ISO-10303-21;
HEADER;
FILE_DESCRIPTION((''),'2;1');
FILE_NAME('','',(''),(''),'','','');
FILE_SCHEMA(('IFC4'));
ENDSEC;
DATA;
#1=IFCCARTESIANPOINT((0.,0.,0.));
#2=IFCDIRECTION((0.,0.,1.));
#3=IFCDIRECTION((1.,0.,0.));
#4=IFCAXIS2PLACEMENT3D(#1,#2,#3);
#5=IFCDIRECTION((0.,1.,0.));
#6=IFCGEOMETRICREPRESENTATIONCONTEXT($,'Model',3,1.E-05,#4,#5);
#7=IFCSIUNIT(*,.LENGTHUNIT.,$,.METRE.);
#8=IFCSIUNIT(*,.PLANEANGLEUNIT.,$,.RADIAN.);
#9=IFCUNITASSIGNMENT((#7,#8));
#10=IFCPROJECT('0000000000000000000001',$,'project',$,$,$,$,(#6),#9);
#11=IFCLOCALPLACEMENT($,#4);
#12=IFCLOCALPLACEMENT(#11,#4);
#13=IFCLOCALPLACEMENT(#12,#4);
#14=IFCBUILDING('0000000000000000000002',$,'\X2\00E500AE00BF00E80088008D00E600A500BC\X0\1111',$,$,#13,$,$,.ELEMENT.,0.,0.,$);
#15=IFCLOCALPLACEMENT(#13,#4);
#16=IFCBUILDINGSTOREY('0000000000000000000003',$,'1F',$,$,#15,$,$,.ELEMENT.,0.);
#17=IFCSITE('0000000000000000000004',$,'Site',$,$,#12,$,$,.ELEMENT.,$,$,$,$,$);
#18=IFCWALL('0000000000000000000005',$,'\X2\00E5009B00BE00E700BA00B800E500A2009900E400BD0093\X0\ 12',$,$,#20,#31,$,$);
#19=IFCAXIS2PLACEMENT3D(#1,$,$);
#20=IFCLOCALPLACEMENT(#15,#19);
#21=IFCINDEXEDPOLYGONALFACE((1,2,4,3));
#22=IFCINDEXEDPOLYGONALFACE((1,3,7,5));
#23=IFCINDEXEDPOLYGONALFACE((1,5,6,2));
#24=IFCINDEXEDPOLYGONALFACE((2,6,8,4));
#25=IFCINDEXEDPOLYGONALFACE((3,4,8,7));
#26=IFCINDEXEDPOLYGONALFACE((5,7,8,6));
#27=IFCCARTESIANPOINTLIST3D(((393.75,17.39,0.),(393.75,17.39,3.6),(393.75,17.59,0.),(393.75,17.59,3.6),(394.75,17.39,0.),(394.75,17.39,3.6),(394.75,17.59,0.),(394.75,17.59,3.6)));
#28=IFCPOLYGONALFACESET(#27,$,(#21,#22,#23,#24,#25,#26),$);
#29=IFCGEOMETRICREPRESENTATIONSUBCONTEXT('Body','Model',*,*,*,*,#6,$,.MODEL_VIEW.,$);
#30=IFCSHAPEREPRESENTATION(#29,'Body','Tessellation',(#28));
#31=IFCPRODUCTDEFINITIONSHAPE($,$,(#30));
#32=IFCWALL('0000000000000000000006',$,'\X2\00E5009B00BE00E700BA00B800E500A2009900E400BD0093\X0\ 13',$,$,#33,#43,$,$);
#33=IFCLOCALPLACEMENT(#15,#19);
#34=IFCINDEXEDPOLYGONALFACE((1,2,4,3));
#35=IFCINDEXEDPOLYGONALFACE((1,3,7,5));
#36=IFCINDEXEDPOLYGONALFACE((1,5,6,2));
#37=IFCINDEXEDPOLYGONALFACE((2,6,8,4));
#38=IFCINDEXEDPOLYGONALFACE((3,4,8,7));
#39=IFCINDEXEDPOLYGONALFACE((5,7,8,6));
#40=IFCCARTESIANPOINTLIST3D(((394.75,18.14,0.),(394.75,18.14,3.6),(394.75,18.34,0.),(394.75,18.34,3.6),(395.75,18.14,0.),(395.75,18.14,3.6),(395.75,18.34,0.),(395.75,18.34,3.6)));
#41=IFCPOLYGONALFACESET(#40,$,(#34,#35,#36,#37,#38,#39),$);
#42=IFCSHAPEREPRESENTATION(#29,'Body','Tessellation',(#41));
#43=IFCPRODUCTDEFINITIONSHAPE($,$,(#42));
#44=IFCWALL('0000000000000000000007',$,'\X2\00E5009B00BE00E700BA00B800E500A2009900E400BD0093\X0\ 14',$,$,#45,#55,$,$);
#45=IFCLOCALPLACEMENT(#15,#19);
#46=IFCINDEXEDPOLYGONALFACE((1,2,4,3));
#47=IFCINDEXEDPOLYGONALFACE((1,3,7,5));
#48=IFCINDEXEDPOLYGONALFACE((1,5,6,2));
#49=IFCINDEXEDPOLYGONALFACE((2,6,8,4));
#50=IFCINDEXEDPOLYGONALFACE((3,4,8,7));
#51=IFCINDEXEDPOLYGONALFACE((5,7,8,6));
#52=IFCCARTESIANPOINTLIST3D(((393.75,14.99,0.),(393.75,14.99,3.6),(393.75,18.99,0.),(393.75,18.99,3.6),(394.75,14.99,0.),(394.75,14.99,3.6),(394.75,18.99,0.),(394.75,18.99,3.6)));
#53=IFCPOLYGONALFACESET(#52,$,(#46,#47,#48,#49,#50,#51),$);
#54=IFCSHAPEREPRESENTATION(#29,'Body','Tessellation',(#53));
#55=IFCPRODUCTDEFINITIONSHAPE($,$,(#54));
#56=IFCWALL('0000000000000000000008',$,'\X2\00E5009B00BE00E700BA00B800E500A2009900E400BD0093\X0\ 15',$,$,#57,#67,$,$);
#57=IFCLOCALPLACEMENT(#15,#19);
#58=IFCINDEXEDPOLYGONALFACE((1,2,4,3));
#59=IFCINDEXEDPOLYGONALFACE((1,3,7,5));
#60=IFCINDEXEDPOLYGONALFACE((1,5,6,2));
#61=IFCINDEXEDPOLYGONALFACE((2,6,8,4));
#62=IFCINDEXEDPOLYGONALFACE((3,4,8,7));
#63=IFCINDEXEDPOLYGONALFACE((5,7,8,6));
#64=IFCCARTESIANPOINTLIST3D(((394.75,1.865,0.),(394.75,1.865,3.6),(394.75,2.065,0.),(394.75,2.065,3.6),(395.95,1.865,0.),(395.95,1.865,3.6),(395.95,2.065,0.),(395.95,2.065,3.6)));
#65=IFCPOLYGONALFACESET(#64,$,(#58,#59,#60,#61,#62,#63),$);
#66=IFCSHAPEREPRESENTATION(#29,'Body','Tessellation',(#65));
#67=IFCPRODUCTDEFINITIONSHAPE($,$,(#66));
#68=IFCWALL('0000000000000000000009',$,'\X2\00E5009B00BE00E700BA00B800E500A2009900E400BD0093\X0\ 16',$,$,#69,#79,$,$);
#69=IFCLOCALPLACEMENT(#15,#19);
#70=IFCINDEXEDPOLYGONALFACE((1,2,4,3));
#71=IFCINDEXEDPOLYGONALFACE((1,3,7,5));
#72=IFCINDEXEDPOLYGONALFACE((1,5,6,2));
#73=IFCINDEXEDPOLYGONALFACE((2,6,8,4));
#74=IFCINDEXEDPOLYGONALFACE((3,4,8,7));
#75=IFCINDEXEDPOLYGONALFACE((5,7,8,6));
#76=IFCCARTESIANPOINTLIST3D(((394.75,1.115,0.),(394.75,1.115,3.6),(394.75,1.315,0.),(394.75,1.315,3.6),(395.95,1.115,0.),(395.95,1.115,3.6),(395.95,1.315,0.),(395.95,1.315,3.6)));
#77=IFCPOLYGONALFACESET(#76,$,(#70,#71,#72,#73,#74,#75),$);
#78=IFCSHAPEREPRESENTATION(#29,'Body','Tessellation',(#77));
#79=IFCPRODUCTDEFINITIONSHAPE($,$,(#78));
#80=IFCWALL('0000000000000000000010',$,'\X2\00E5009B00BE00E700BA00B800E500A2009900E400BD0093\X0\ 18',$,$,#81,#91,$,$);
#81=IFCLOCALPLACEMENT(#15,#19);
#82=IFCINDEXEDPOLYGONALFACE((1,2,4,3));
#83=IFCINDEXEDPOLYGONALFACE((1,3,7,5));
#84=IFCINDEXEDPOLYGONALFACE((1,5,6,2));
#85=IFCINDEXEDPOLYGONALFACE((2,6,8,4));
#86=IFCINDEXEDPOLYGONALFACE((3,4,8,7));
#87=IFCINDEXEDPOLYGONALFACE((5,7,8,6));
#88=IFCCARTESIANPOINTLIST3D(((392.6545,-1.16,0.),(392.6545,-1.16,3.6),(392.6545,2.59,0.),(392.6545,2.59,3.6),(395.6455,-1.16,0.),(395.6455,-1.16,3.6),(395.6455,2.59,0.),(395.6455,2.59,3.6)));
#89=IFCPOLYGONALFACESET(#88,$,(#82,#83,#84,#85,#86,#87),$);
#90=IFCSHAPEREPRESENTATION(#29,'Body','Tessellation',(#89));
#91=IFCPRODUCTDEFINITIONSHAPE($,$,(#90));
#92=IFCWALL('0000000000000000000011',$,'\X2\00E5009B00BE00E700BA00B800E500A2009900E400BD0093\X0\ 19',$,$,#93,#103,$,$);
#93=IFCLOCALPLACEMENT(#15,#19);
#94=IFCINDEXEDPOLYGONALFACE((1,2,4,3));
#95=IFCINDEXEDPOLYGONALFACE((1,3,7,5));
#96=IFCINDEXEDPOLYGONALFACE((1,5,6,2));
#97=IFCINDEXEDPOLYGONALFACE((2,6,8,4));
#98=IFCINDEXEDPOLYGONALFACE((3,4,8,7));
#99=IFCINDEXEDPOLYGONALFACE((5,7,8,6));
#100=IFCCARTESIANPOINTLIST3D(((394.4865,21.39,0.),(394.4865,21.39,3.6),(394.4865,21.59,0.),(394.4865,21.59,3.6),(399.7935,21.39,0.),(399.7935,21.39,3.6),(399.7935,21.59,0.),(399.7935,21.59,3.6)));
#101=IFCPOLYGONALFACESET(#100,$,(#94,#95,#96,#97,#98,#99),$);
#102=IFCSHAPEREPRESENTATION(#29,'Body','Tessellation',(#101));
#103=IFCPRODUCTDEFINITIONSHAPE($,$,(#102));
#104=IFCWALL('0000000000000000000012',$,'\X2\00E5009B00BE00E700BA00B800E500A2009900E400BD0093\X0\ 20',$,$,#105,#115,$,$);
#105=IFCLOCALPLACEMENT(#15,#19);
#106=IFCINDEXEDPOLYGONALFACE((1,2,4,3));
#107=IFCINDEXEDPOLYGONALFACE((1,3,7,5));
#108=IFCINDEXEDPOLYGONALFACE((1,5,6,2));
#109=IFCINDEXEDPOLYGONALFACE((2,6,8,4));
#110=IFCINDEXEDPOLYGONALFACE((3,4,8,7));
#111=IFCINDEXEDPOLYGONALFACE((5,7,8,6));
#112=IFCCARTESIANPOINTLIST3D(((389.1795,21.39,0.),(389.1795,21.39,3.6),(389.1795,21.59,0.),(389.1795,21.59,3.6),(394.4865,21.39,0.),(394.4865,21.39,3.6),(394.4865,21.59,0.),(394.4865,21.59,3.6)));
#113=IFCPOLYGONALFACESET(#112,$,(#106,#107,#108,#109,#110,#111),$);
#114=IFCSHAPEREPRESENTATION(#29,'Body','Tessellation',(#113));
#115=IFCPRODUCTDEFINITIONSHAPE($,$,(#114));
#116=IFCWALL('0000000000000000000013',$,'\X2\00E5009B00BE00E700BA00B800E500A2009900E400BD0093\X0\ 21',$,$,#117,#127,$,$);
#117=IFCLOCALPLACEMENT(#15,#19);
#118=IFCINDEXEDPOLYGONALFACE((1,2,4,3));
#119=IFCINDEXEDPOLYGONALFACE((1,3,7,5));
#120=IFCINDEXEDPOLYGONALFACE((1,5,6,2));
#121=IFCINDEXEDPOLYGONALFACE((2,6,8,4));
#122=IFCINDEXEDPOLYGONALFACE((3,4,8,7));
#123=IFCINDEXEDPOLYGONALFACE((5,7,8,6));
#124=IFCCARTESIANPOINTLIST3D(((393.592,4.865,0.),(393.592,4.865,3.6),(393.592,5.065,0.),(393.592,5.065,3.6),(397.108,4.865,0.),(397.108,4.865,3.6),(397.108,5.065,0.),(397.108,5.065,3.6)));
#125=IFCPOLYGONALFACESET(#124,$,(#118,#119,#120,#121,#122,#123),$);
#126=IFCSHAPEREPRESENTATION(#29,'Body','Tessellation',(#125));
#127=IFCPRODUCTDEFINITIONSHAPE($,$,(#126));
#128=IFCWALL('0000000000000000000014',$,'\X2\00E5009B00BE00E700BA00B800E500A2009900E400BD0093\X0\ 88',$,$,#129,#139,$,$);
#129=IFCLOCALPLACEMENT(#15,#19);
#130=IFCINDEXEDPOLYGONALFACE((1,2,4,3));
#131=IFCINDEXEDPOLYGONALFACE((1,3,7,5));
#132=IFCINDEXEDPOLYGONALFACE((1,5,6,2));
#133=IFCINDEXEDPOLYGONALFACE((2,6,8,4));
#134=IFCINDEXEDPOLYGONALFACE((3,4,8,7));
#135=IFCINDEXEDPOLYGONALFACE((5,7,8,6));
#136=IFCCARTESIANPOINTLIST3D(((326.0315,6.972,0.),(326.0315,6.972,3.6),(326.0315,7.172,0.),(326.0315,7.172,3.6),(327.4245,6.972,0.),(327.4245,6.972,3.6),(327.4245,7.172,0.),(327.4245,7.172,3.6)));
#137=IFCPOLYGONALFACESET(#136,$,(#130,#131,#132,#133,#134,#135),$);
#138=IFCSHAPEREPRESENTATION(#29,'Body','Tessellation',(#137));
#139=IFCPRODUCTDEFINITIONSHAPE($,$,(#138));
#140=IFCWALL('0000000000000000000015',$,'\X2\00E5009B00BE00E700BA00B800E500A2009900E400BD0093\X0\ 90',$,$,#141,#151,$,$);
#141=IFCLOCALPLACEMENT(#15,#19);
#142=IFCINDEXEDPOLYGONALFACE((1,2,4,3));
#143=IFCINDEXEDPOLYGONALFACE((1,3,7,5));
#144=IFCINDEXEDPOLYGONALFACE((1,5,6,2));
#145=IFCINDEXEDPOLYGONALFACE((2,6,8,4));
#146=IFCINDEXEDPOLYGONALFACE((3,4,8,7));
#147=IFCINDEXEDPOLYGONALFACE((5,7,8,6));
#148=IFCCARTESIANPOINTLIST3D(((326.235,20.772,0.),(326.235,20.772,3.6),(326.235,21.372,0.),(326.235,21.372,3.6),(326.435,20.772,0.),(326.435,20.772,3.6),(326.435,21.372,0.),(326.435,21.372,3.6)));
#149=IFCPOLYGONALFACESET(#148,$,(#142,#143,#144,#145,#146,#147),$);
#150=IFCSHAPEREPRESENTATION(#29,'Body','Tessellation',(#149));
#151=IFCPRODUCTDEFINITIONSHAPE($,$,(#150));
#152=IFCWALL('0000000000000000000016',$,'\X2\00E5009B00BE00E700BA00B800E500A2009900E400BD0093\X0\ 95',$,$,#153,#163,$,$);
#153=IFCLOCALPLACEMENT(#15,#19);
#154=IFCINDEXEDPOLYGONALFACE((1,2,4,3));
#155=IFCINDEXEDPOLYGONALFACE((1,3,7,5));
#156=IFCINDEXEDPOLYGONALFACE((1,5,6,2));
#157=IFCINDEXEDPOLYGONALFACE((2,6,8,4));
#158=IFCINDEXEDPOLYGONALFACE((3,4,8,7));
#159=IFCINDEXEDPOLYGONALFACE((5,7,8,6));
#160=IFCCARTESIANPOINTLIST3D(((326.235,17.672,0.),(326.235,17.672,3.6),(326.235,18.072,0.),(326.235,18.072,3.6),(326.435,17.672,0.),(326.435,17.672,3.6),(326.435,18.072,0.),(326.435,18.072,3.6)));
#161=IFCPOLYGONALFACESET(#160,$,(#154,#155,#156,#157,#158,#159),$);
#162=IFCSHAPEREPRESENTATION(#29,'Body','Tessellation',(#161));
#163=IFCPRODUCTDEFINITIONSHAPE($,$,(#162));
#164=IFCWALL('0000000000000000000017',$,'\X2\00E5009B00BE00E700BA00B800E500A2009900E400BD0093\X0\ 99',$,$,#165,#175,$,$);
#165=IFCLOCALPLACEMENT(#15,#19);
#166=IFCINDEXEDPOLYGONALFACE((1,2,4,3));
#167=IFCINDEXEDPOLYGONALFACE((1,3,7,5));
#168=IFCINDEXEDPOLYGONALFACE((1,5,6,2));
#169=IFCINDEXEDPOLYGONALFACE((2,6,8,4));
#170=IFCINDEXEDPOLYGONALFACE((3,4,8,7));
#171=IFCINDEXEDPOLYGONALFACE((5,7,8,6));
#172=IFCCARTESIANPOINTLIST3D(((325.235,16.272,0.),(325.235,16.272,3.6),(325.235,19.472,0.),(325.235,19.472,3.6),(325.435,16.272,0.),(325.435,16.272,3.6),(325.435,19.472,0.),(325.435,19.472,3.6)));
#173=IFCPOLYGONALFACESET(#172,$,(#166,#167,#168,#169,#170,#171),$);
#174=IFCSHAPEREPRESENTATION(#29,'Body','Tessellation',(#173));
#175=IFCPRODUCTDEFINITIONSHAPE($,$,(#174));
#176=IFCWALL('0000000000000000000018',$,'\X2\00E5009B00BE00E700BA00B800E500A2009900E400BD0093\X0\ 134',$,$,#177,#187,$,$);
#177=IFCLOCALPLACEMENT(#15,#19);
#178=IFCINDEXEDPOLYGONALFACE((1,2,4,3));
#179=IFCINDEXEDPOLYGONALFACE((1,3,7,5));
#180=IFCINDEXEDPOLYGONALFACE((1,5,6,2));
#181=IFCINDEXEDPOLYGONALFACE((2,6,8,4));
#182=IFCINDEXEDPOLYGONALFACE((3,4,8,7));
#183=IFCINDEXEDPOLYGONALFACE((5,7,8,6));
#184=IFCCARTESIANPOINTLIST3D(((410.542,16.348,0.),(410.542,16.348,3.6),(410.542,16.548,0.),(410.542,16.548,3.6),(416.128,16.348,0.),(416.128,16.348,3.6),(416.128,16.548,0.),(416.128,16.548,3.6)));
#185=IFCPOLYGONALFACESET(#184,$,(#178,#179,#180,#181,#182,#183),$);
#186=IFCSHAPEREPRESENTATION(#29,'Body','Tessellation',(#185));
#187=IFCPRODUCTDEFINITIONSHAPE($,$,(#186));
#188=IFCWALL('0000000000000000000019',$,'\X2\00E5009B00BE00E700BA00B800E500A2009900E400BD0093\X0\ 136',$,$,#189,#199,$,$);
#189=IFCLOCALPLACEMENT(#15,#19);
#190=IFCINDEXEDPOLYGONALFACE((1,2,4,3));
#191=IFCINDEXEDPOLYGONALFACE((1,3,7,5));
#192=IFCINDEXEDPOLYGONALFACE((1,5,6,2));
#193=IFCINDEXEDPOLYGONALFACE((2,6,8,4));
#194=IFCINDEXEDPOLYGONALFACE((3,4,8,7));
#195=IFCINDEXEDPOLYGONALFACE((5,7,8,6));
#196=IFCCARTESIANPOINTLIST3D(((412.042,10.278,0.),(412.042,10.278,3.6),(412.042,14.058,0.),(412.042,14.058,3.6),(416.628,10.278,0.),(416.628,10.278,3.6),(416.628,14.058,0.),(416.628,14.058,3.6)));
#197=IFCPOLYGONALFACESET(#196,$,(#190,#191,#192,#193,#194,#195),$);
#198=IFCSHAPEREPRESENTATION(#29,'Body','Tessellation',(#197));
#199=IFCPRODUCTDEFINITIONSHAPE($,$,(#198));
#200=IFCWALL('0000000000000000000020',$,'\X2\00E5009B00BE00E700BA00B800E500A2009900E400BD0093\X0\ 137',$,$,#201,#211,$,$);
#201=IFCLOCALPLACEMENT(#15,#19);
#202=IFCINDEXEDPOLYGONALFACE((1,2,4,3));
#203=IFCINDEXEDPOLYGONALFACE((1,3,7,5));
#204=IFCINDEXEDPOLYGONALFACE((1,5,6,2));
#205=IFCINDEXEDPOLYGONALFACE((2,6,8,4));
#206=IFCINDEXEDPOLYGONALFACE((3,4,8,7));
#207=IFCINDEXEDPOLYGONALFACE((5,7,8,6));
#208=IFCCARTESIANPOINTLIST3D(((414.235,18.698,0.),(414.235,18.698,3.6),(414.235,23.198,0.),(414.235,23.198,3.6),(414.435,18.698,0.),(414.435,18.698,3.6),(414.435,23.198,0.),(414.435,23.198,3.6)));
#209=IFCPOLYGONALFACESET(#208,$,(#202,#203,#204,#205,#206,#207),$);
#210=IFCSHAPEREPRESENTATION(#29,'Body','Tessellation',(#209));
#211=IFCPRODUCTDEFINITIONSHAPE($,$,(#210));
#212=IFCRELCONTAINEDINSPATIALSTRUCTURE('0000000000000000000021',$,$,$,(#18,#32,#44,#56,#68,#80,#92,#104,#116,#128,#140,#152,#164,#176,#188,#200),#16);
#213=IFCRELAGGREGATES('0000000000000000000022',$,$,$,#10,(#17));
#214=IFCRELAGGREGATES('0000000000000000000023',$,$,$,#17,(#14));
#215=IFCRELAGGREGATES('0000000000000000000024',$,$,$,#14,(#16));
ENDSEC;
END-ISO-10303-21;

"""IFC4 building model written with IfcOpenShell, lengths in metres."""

from ifc_helpers import new_model, si_unit, direction, frame, frame_2d, origin_with_axes, place, context, subcontext, project, spatial, rectangle, extrude, element, save


model = new_model("IFC4")

# Units and contexts
model_context = context("Model", 3, precision=1e-05, world=origin_with_axes(), true_north=direction((0.0, 1.0, 0.0)))
body_context = subcontext(model_context, "Body", "Model", "MODEL_VIEW")
ifc_project = project(units=[si_unit("LENGTHUNIT", "METRE"), si_unit("PLANEANGLEUNIT", "RADIAN")], contexts=[model_context])

# Site, building, storey
placement = place(None, origin_with_axes())
site_placement = place(placement, origin_with_axes())
site = spatial("IfcSite", under=ifc_project, at=site_placement, Name="Site", CompositionType="ELEMENT")
building_placement = place(site_placement, origin_with_axes())
building = spatial("IfcBuilding", under=site, at=building_placement, Name="å®¿è\u0088\u008dæ¥¼1111", CompositionType="ELEMENT", ElevationOfRefHeight=0.0, ElevationOfTerrain=0.0)
storey_placement = place(building_placement, origin_with_axes())
storey = spatial("IfcBuildingStorey", under=building, at=storey_placement, Name="1F", CompositionType="ELEMENT", Elevation=0.0)

# Walls
for number, where, z_axis, x_axis, name in (
    (1, (394.25, 17.49, 0.0), (0.0, 0.0, 1.0), (1.0, 0.0, 0.0), "å\u009b¾çº¸å¢\u0099ä½\u0093 12"),
    (2, (395.25, 18.24, 0.0), (0.0, 0.0, 1.0), (-1.0, 0.0, 0.0), "å\u009b¾çº¸å¢\u0099ä½\u0093 13"),
):
    element("IfcWall", number, at=place(storey_placement, frame(where, z_axis=z_axis, x_axis=x_axis)), inside=storey, Name=name, context=body_context, shape_type="SweptSolid", body=[
        extrude(rectangle(XDim=1.0, YDim=0.2, at=frame_2d((0.0, 0.0), x_axis=(1.0, 0.0, 0.0))), frame((0.0, 0.0, 0.0), z_axis=(0.0, 0.0, 1.0)), (0.0, 0.0, 1.0), 3.6),
    ])
wall_1_placement = place(storey_placement, frame((394.25, 16.99, 0.0), z_axis=(0.0, 0.0, 1.0), x_axis=(1.0, 0.0, 0.0)))
element("IfcWall", 3, at=wall_1_placement, inside=storey, Name="å\u009b¾çº¸å¢\u0099ä½\u0093 14", context=body_context, shape_type="SweptSolid", body=[
    extrude(rectangle(XDim=1.0, YDim=4.0, at=frame_2d((0.0, 0.0), x_axis=(1.0, 0.0, 0.0))), frame((0.0, 0.0, 0.0), z_axis=(0.0, 0.0, 1.0)), (0.0, 0.0, 1.0), 3.6),
])
for number, where, z_axis, x_axis, name in (
    (4, (395.35, 1.965, 0.0), (0.0, 0.0, 1.0), (-1.0, 0.0, 0.0), "å\u009b¾çº¸å¢\u0099ä½\u0093 15"),
    (5, (395.35, 1.215, 0.0), (0.0, 0.0, 1.0), (-1.0, 0.0, 0.0), "å\u009b¾çº¸å¢\u0099ä½\u0093 16"),
):
    element("IfcWall", number, at=place(storey_placement, frame(where, z_axis=z_axis, x_axis=x_axis)), inside=storey, Name=name, context=body_context, shape_type="SweptSolid", body=[
        extrude(rectangle(XDim=1.2, YDim=0.2, at=frame_2d((0.0, 0.0), x_axis=(1.0, 0.0, 0.0))), frame((0.0, 0.0, 0.0), z_axis=(0.0, 0.0, 1.0)), (0.0, 0.0, 1.0), 3.6),
    ])
wall_2_placement = place(storey_placement, frame((394.15, 0.715, 0.0), z_axis=(0.0, 0.0, 1.0), x_axis=(1.0, 0.0, 0.0)))
element("IfcWall", 6, at=wall_2_placement, inside=storey, Name="å\u009b¾çº¸å¢\u0099ä½\u0093 18", context=body_context, shape_type="SweptSolid", body=[
    extrude(rectangle(XDim=2.991, YDim=3.75, at=frame_2d((0.0, 0.0), x_axis=(1.0, 0.0, 0.0))), frame((0.0, 0.0, 0.0), z_axis=(0.0, 0.0, 1.0)), (0.0, 0.0, 1.0), 3.6),
])
for number, where, z_axis, x_axis, name in (
    (7, (397.14, 21.49, 0.0), (0.0, 0.0, 1.0), (-1.0, 0.0, 0.0), "å\u009b¾çº¸å¢\u0099ä½\u0093 19"),
    (8, (391.833, 21.49, 0.0), (0.0, 0.0, 1.0), (1.0, 0.0, 0.0), "å\u009b¾çº¸å¢\u0099ä½\u0093 20"),
):
    element("IfcWall", number, at=place(storey_placement, frame(where, z_axis=z_axis, x_axis=x_axis)), inside=storey, Name=name, context=body_context, shape_type="SweptSolid", body=[
        extrude(rectangle(XDim=5.307, YDim=0.2, at=frame_2d((0.0, 0.0), x_axis=(1.0, 0.0, 0.0))), frame((0.0, 0.0, 0.0), z_axis=(0.0, 0.0, 1.0)), (0.0, 0.0, 1.0), 3.6),
    ])
wall_3_placement = place(storey_placement, frame((395.35, 4.965, 0.0), z_axis=(0.0, 0.0, 1.0), x_axis=(-1.0, 0.0, 0.0)))
element("IfcWall", 9, at=wall_3_placement, inside=storey, Name="å\u009b¾çº¸å¢\u0099ä½\u0093 21", context=body_context, shape_type="SweptSolid", body=[
    extrude(rectangle(XDim=3.516, YDim=0.2, at=frame_2d((0.0, 0.0), x_axis=(1.0, 0.0, 0.0))), frame((0.0, 0.0, 0.0), z_axis=(0.0, 0.0, 1.0)), (0.0, 0.0, 1.0), 3.6),
])
wall_4_placement = place(storey_placement, frame((326.728, 7.072, 0.0), z_axis=(0.0, 0.0, 1.0), x_axis=(-1.0, 0.0, 0.0)))
element("IfcWall", 10, at=wall_4_placement, inside=storey, Name="å\u009b¾çº¸å¢\u0099ä½\u0093 88", context=body_context, shape_type="SweptSolid", body=[
    extrude(rectangle(XDim=1.393, YDim=0.2, at=frame_2d((0.0, 0.0), x_axis=(1.0, 0.0, 0.0))), frame((0.0, 0.0, 0.0), z_axis=(0.0, 0.0, 1.0)), (0.0, 0.0, 1.0), 3.6),
])
wall_5_placement = place(storey_placement, frame((326.335, 21.072, 0.0), z_axis=(0.0, 0.0, 1.0), x_axis=(0.0, 1.0, 0.0)))
element("IfcWall", 11, at=wall_5_placement, inside=storey, Name="å\u009b¾çº¸å¢\u0099ä½\u0093 90", context=body_context, shape_type="SweptSolid", body=[
    extrude(rectangle(XDim=0.6, YDim=0.2, at=frame_2d((0.0, 0.0), x_axis=(1.0, 0.0, 0.0))), frame((0.0, 0.0, 0.0), z_axis=(0.0, 0.0, 1.0)), (0.0, 0.0, 1.0), 3.6),
])
wall_6_placement = place(storey_placement, frame((326.335, 17.872, 0.0), z_axis=(0.0, 0.0, 1.0), x_axis=(0.0, -1.0, 0.0)))
element("IfcWall", 12, at=wall_6_placement, inside=storey, Name="å\u009b¾çº¸å¢\u0099ä½\u0093 95", context=body_context, shape_type="SweptSolid", body=[
    extrude(rectangle(XDim=0.4, YDim=0.2, at=frame_2d((0.0, 0.0), x_axis=(1.0, 0.0, 0.0))), frame((0.0, 0.0, 0.0), z_axis=(0.0, 0.0, 1.0)), (0.0, 0.0, 1.0), 3.6),
])
wall_7_placement = place(storey_placement, frame((325.335, 17.872, 0.0), z_axis=(0.0, 0.0, 1.0), x_axis=(0.0, 1.0, 0.0)))
element("IfcWall", 13, at=wall_7_placement, inside=storey, Name="å\u009b¾çº¸å¢\u0099ä½\u0093 99", context=body_context, shape_type="SweptSolid", body=[
    extrude(rectangle(XDim=3.2, YDim=0.2, at=frame_2d((0.0, 0.0), x_axis=(1.0, 0.0, 0.0))), frame((0.0, 0.0, 0.0), z_axis=(0.0, 0.0, 1.0)), (0.0, 0.0, 1.0), 3.6),
])
wall_8_placement = place(storey_placement, frame((413.335, 16.448, 0.0), z_axis=(0.0, 0.0, 1.0), x_axis=(1.0, 0.0, 0.0)))
element("IfcWall", 14, at=wall_8_placement, inside=storey, Name="å\u009b¾çº¸å¢\u0099ä½\u0093 134", context=body_context, shape_type="SweptSolid", body=[
    extrude(rectangle(XDim=5.586, YDim=0.2, at=frame_2d((0.0, 0.0), x_axis=(1.0, 0.0, 0.0))), frame((0.0, 0.0, 0.0), z_axis=(0.0, 0.0, 1.0)), (0.0, 0.0, 1.0), 3.6),
])
wall_9_placement = place(storey_placement, frame((414.335, 12.168, 0.0), z_axis=(0.0, 0.0, 1.0), x_axis=(1.0, 0.0, 0.0)))
element("IfcWall", 15, at=wall_9_placement, inside=storey, Name="å\u009b¾çº¸å¢\u0099ä½\u0093 136", context=body_context, shape_type="SweptSolid", body=[
    extrude(rectangle(XDim=4.586, YDim=3.78, at=frame_2d((0.0, 0.0), x_axis=(1.0, 0.0, 0.0))), frame((0.0, 0.0, 0.0), z_axis=(0.0, 0.0, 1.0)), (0.0, 0.0, 1.0), 3.6),
])
wall_10_placement = place(storey_placement, frame((414.335, 20.948, 0.0), z_axis=(0.0, 0.0, 1.0), x_axis=(0.0, -1.0, 0.0)))
element("IfcWall", 16, at=wall_10_placement, inside=storey, Name="å\u009b¾çº¸å¢\u0099ä½\u0093 137", context=body_context, shape_type="SweptSolid", body=[
    extrude(rectangle(XDim=4.5, YDim=0.2, at=frame_2d((0.0, 0.0), x_axis=(1.0, 0.0, 0.0))), frame((0.0, 0.0, 0.0), z_axis=(0.0, 0.0, 1.0)), (0.0, 0.0, 1.0), 3.6),
])

save(model, "model.ifc")
